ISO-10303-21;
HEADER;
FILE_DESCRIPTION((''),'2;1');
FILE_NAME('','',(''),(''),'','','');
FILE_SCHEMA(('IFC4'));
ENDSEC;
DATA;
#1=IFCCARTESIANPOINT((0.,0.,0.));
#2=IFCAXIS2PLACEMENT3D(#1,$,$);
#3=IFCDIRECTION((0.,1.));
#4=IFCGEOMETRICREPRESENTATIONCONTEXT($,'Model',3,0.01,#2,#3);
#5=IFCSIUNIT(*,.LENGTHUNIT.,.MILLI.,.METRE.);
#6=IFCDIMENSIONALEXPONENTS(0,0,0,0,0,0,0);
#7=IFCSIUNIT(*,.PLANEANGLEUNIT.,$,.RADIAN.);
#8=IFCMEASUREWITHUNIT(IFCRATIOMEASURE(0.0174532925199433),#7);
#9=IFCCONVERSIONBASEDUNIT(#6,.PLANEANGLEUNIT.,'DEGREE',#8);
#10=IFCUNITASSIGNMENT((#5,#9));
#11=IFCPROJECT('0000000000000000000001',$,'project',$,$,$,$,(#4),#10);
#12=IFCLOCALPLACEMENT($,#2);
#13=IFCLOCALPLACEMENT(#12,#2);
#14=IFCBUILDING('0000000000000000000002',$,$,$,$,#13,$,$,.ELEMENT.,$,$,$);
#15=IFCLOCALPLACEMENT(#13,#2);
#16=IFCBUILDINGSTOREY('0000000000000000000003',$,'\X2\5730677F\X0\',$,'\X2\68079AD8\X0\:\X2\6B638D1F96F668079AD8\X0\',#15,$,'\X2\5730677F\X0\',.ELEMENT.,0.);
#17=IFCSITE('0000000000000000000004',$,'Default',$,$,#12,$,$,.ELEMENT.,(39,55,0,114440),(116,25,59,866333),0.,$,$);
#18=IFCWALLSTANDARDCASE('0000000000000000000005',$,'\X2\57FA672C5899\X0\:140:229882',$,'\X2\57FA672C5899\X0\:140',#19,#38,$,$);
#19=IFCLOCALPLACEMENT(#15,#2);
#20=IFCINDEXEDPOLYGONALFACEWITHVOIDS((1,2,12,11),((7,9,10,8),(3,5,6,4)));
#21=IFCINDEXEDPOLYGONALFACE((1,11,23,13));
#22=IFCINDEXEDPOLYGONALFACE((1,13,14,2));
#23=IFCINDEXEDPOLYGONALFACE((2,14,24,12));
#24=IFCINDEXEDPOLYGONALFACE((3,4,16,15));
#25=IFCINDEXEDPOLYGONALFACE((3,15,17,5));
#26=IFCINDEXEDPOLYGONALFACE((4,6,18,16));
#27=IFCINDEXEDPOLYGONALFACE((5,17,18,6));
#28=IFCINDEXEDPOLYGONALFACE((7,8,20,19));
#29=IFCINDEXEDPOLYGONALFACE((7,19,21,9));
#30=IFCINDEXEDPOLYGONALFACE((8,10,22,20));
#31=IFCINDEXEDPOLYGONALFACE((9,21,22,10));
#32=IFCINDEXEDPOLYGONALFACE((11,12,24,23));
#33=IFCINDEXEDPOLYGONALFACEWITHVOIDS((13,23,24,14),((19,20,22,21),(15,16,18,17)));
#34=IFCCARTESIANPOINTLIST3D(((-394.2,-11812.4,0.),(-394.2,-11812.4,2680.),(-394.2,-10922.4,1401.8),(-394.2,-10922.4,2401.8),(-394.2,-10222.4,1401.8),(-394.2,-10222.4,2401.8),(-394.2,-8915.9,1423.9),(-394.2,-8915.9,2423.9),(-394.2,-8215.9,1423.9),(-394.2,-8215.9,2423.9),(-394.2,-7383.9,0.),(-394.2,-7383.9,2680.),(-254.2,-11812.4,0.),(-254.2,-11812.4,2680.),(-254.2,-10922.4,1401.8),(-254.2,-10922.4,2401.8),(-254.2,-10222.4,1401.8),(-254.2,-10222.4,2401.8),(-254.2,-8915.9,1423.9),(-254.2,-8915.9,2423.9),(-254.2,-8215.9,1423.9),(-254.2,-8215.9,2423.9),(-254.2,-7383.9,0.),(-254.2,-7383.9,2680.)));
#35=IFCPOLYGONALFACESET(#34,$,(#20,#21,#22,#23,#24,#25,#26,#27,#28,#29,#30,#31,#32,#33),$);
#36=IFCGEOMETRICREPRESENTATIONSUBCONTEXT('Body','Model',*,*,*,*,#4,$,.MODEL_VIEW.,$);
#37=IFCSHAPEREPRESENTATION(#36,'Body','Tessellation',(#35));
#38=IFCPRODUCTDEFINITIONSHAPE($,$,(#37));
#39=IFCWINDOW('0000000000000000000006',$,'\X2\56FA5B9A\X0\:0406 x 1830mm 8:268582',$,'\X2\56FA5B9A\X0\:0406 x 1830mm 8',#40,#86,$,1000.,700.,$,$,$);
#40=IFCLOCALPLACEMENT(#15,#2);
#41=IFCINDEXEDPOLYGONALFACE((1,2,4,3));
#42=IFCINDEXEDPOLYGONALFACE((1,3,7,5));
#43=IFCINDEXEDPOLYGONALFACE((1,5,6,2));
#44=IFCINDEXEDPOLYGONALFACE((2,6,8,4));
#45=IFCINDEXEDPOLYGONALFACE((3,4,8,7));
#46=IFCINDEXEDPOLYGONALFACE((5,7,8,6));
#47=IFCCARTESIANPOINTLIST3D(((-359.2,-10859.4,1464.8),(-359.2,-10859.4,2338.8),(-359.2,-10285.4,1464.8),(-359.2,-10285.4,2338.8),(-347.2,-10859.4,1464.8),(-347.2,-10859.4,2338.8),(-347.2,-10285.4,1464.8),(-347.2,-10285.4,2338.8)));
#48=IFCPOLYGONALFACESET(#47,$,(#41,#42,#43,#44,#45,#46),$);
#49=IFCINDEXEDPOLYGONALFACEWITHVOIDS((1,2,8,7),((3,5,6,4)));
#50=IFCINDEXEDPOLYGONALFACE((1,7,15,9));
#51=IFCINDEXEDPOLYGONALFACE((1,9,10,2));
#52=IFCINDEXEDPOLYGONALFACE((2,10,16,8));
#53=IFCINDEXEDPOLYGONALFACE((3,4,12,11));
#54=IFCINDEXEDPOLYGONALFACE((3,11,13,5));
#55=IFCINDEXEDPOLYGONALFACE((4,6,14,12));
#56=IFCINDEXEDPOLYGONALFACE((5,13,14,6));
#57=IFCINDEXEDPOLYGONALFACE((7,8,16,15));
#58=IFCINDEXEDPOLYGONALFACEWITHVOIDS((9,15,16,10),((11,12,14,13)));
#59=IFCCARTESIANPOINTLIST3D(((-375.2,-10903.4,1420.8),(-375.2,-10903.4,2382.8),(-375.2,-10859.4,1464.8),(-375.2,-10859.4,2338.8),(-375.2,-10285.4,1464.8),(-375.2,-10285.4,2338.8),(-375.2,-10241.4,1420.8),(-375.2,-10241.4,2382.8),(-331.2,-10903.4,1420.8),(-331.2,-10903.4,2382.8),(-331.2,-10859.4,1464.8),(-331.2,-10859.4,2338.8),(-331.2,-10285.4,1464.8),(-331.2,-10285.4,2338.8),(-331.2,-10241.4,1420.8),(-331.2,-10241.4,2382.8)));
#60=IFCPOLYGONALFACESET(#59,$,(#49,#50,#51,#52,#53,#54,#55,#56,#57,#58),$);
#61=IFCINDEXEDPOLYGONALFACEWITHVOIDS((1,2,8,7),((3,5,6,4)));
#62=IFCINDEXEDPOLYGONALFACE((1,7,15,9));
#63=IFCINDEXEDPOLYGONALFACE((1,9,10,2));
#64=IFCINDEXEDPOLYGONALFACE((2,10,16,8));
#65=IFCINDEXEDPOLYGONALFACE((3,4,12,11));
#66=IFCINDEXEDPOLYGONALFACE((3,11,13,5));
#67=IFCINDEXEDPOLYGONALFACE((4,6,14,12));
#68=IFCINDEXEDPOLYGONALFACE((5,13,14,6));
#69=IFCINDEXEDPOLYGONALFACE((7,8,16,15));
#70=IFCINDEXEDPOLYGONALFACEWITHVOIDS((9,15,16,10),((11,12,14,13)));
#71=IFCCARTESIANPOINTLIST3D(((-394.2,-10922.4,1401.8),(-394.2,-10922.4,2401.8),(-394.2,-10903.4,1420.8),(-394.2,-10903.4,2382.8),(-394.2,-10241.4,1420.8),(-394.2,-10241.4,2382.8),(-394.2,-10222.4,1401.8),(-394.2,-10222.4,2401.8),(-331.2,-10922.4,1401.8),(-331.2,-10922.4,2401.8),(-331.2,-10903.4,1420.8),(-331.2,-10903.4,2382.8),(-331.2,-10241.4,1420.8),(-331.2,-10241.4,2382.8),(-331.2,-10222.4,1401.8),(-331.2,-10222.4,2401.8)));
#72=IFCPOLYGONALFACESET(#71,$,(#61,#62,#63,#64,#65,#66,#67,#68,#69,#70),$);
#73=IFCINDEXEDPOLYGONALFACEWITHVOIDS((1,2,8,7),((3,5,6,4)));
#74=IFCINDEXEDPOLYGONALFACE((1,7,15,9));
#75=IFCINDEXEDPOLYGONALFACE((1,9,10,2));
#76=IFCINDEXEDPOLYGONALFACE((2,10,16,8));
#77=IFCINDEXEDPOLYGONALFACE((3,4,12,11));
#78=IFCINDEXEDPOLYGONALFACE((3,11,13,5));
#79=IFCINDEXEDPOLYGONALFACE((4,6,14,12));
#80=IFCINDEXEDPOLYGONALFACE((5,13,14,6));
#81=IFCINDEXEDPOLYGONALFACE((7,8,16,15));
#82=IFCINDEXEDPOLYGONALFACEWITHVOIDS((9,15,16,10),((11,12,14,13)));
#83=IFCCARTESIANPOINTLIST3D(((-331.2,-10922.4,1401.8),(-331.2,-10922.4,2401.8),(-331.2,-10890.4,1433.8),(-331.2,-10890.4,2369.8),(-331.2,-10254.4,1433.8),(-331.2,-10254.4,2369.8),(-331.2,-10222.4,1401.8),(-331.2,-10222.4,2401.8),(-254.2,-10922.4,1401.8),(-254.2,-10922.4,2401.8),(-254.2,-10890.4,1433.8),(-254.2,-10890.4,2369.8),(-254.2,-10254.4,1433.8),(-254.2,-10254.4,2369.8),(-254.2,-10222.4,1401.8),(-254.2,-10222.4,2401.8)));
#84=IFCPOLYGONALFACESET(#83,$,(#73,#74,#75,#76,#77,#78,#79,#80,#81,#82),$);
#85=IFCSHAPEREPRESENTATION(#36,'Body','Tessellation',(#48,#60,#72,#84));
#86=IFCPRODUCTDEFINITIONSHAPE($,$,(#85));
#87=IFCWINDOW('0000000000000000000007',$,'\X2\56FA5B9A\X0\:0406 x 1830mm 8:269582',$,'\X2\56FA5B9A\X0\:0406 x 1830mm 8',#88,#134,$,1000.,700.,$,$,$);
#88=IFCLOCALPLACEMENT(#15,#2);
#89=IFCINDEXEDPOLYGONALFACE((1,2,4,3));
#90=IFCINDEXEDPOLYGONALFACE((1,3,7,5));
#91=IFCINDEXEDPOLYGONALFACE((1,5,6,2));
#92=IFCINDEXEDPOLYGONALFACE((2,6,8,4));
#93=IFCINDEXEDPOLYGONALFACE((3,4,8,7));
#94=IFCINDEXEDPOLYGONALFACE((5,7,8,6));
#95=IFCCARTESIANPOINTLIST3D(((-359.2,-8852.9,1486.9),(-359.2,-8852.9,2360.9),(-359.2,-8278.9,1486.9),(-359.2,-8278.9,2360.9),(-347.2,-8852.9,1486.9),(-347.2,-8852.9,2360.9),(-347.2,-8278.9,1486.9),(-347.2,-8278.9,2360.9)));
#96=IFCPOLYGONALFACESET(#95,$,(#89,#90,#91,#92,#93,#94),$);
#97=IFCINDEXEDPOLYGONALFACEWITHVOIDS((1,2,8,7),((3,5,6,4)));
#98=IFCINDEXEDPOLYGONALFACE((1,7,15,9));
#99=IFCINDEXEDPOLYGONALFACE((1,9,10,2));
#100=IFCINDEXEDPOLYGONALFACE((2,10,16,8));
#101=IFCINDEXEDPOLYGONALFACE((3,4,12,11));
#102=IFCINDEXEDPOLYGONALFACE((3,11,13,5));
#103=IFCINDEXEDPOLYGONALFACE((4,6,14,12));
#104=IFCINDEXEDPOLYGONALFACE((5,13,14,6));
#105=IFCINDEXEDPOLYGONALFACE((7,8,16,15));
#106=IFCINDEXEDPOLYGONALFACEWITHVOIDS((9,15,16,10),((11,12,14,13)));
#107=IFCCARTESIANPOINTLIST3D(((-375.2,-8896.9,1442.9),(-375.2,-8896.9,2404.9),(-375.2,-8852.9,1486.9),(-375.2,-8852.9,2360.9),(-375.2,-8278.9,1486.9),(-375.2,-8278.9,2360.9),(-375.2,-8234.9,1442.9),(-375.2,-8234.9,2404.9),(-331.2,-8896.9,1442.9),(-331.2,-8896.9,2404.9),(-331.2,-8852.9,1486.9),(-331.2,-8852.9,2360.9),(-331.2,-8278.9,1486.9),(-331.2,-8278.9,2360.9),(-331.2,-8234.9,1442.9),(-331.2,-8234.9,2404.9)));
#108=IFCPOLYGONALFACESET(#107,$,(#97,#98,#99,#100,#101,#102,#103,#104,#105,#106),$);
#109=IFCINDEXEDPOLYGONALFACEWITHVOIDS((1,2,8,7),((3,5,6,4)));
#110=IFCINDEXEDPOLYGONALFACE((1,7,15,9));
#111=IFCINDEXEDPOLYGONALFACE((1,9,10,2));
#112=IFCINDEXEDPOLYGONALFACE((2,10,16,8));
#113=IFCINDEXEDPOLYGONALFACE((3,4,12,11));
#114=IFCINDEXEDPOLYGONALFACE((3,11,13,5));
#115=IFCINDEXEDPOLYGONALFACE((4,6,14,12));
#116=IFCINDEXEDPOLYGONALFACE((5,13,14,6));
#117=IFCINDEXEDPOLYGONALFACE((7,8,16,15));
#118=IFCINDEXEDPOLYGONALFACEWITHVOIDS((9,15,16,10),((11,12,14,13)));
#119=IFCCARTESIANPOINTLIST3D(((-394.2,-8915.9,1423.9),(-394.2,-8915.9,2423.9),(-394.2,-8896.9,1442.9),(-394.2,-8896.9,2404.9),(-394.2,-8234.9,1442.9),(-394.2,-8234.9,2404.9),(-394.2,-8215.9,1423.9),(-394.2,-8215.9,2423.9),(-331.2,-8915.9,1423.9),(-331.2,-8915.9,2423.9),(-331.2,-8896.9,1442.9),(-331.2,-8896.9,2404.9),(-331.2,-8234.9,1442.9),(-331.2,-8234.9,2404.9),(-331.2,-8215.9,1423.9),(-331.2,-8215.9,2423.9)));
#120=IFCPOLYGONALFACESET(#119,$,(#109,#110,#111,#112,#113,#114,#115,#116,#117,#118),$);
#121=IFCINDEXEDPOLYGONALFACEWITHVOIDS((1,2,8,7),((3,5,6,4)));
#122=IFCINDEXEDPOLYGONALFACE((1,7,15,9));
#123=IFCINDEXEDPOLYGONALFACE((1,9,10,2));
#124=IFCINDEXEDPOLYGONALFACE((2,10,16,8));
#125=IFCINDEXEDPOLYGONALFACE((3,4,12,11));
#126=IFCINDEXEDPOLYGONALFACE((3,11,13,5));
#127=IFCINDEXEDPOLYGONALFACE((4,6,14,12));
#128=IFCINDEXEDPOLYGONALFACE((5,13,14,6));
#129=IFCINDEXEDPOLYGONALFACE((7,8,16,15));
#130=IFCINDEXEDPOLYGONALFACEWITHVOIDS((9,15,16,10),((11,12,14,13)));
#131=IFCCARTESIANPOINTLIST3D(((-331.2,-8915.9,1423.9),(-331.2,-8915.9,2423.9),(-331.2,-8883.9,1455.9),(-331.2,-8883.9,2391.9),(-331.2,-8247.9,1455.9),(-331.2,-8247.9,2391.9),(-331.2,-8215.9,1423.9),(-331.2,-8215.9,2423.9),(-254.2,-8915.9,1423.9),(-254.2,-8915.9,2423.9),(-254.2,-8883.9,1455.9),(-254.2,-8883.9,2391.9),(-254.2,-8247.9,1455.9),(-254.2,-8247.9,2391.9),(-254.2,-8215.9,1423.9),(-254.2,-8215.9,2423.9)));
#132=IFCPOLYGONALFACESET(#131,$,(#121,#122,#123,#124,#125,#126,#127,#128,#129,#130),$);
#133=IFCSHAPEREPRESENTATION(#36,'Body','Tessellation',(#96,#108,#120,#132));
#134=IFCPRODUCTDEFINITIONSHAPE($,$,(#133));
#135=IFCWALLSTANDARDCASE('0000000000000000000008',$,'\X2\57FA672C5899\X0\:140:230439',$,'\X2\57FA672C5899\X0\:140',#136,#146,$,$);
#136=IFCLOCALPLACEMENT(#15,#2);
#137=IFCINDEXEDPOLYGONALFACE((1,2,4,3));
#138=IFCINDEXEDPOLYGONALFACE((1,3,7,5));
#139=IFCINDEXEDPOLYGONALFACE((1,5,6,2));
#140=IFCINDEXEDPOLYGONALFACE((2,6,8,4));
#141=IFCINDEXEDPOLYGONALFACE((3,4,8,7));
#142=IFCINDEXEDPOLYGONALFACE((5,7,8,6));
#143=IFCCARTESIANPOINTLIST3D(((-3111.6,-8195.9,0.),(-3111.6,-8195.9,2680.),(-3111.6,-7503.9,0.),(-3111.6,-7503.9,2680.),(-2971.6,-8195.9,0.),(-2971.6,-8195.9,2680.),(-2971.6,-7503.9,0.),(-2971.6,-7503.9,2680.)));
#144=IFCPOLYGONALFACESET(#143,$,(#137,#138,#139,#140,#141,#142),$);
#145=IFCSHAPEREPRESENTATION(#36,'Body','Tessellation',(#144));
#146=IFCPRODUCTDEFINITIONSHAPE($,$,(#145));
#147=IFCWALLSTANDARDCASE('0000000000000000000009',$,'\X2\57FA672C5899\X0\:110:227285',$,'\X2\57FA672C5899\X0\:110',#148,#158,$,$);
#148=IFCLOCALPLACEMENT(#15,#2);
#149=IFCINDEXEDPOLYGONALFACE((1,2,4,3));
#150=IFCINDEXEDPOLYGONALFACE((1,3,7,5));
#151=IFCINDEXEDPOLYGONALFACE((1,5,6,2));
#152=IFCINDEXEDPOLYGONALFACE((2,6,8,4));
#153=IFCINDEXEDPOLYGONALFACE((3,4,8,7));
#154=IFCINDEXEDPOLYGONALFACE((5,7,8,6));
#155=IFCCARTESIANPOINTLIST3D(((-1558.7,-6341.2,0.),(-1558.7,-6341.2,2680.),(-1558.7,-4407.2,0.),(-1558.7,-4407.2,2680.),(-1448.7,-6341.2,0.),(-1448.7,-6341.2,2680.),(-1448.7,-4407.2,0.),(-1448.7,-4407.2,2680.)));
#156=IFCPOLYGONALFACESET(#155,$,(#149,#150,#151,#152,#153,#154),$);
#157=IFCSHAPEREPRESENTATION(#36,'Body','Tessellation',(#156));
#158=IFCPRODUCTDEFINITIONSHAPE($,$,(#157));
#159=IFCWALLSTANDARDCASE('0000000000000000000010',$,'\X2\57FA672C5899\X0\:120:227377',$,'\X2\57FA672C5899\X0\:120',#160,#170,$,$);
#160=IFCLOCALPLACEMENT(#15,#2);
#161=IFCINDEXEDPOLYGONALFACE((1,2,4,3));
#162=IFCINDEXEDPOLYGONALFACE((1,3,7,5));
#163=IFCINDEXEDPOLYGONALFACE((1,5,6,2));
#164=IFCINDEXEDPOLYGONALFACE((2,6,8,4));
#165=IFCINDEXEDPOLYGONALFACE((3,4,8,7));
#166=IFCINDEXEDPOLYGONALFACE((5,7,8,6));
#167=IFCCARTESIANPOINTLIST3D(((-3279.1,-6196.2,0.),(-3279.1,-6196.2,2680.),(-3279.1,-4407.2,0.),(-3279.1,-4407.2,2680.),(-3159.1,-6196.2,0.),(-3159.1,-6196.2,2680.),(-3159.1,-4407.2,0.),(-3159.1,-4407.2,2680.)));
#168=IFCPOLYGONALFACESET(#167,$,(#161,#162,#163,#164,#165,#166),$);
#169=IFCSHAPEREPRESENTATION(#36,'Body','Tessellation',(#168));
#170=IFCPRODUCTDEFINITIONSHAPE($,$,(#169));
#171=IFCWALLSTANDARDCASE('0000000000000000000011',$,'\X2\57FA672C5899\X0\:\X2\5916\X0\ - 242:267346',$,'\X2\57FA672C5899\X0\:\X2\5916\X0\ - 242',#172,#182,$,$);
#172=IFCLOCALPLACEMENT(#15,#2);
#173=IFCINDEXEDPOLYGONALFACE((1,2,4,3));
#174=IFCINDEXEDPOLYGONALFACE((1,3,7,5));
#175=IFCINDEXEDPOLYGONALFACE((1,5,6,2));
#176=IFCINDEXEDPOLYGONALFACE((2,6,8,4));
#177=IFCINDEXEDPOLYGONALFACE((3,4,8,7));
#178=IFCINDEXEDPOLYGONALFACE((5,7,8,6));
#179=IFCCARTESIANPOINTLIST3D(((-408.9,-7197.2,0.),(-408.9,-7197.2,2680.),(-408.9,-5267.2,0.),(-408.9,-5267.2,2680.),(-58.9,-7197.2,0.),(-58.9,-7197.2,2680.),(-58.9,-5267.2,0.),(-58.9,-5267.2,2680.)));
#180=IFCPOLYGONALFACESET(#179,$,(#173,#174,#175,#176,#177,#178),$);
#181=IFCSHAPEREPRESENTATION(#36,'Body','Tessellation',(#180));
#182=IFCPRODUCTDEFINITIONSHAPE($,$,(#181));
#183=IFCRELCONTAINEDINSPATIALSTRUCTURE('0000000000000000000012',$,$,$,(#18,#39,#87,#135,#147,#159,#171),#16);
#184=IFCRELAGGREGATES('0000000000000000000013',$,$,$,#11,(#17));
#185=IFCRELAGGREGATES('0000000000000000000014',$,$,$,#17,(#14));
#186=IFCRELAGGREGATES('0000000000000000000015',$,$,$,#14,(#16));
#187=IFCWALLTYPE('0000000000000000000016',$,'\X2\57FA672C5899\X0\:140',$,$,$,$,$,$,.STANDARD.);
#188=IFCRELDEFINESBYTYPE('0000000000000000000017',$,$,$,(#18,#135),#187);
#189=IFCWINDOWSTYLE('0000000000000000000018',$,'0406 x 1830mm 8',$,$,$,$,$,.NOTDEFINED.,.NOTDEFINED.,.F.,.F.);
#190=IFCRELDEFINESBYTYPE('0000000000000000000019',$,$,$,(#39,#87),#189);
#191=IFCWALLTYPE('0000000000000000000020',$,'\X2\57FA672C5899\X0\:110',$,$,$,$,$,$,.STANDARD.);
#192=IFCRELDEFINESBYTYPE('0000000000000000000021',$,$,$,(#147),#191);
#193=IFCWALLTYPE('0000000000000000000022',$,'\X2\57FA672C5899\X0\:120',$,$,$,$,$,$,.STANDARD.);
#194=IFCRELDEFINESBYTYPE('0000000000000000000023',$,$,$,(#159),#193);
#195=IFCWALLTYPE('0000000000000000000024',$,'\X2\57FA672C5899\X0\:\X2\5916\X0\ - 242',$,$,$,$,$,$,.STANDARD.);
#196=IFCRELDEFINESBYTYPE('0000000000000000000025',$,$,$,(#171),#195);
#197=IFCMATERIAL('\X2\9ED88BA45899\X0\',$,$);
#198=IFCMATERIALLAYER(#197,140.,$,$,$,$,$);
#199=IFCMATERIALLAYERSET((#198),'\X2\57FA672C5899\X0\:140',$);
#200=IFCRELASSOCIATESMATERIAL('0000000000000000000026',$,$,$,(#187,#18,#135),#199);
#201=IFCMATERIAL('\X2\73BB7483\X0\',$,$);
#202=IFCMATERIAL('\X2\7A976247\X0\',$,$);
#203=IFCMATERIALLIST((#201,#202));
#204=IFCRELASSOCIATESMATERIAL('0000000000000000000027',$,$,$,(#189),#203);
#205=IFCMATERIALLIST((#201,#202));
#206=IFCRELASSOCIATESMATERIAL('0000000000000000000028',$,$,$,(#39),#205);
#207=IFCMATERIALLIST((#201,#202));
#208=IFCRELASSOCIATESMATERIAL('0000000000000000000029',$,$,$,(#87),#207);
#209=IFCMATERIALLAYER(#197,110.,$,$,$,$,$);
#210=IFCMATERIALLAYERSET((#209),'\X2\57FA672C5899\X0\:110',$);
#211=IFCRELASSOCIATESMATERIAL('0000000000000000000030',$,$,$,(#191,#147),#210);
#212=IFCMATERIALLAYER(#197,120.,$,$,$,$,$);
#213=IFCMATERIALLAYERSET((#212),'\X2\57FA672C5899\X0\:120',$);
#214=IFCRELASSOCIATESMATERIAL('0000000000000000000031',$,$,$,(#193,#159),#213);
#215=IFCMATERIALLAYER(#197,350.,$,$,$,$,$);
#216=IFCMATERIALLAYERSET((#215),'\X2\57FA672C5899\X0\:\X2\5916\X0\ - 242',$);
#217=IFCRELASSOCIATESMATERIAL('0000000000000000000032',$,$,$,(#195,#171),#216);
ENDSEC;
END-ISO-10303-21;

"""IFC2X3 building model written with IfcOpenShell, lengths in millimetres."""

from ifc_helpers import new_model, entity, si_unit, converted_unit, direction, frame, frame_2d, origin, origin_2d_with_axis, place, context, subcontext, project, spatial, polyline, rectangle, outline, extrude, source, transform, mapped, material, material_list, layer, layer_set, layer_usage, type_object, type_shapes, element, fill, save


model = new_model("IFC2X3")

# Units and contexts
model_context = context("Model", 3, precision=0.01, world=origin(), true_north=direction((0.0, 1.0)))
body_context = subcontext(model_context, "Body", "Model", "MODEL_VIEW")
ifc_project = project(units=[si_unit("LENGTHUNIT", "METRE", prefix="MILLI"), converted_unit("PLANEANGLEUNIT", "DEGREE", entity("IfcRatioMeasure", 0.0174532925199433), si_unit("PLANEANGLEUNIT", "RADIAN"), dimensions=[0, 0, 0, 0, 0, 0, 0])], contexts=[model_context])

# Site, building, storey
site_placement = place(None, origin())
site = spatial("IfcSite", under=ifc_project, at=site_placement, Name="Default", CompositionType="ELEMENT", RefLatitude=(39, 55, 0, 114440), RefLongitude=(116, 25, 59, 866333), RefElevation=0.0)
building_placement = place(site_placement, origin())
building = spatial("IfcBuilding", under=site, at=building_placement, CompositionType="ELEMENT")
storey_placement = place(building_placement, origin())
storey = spatial("IfcBuildingStorey", under=building, at=storey_placement, Name="地板", ObjectType="标高:正负零标高", LongName="地板", CompositionType="ELEMENT", Elevation=0.0)

# Shared definitions
ifc_material_1 = material(Name="默认墙")

# Shared definitions
ifc_material_2 = material(Name="玻璃")
ifc_material_3 = material(Name="窗扇")

# Shared definitions
ifc_layer_1 = layer(ifc_material_1, 140.0)
ifc_layer_set_1 = layer_set([ifc_layer_1], Name="基本墙:140")
wall_type_1 = type_object("IfcWallType", Name="基本墙:140", PredefinedType="STANDARD", material=ifc_layer_set_1)

# Wall, openings, windows
ifc_layer_usage_1 = layer_usage(ifc_layer_set_1, "AXIS2", "NEGATIVE", 70.0)
wall_1_placement = place(storey_placement, frame((-324.2, -11812.4, 0.0), z_axis=(0.0, 0.0, 1.0), x_axis=(0.0, 1.0, 0.0)))
wall_1 = element("IfcWallStandardCase", 1, at=wall_1_placement, inside=storey, type_object=wall_type_1, material=ifc_layer_usage_1, Name="基本墙:140:229882", ObjectType="基本墙:140", context=body_context, shape_type="SweptSolid", body=[
    extrude(rectangle(XDim=4428.5, YDim=140.0, at=frame_2d((2214.3, 0.0), x_axis=(-1.0, 0.0))), origin(), (0.0, 0.0, 1.0), 2680.0),
])
opening_1_placement = place(wall_1_placement, frame((890.0, -70.0, 1401.8)))
opening_1 = element("IfcOpeningElement", 2, at=opening_1_placement, cuts=wall_1, ObjectType="Opening", context=body_context, shape_type="SweptSolid", body=[
    extrude(rectangle(XDim=1000.0, YDim=700.0, at=frame_2d((500.0, 350.0), x_axis=(1.0, 0.0))), frame((0.0, 0.0, 0.0), z_axis=(0.0, 1.0, 0.0), x_axis=(0.0, 0.0, 1.0)), (0.0, 0.0, 1.0), 140.0),
])
opening_2_placement = place(wall_1_placement, frame((2896.5, -70.0, 1423.9)))
opening_2 = element("IfcOpeningElement", 3, at=opening_2_placement, cuts=wall_1, ObjectType="Opening", context=body_context, shape_type="SweptSolid", body=[
    extrude(rectangle(XDim=1000.0, YDim=700.0, at=frame_2d((500.0, 350.0), x_axis=(1.0, 0.0))), frame((0.0, 0.0, 0.0), z_axis=(0.0, 1.0, 0.0), x_axis=(0.0, 0.0, 1.0)), (0.0, 0.0, 1.0), 140.0),
])
ifc_material_list_1 = material_list([ifc_material_2, ifc_material_3])
ifc_material_list_2 = material_list([ifc_material_2, ifc_material_3])
window_style_1 = type_object("IfcWindowStyle", Name="0406 x 1830mm 8", ConstructionType="NOTDEFINED", OperationType="NOTDEFINED", ParameterTakesPrecedence=False, Sizeable=False, material=ifc_material_list_2)
shared_shape_1 = source(origin(), body_context, "Body", "SweptSolid", [
    extrude(rectangle(XDim=12.0, YDim=574.0, at=origin_2d_with_axis()), frame((350.0, 99.0, 63.0), z_axis=(0.0, 0.0, 1.0), x_axis=(0.0, -1.0, 0.0)), (0.0, 0.0, 1.0), 874.0),
    extrude(outline(polyline([(-331.0, -481.0), (331.0, -481.0), (331.0, 481.0), (-331.0, 481.0), (-331.0, -481.0)]), holes=[polyline([(-287.0, -437.0), (-287.0, 437.0), (287.0, 437.0), (287.0, -437.0), (-287.0, -437.0)])]), frame((350.0, 77.0, 500.0), z_axis=(0.0, 1.0, 0.0), x_axis=(1.0, 0.0, 0.0)), (0.0, 0.0, 1.0), 44.0),
    extrude(outline(polyline([(-350.0, -500.0), (350.0, -500.0), (350.0, 500.0), (-350.0, 500.0), (-350.0, -500.0)]), holes=[polyline([(-331.0, -481.0), (-331.0, 481.0), (331.0, 481.0), (331.0, -481.0), (-331.0, -481.0)])]), frame((350.0, 77.0, 500.0), z_axis=(0.0, 1.0, 0.0), x_axis=(1.0, 0.0, 0.0)), (0.0, 0.0, 1.0), 63.0),
    extrude(outline(polyline([(-350.0, -500.0), (350.0, -500.0), (350.0, 500.0), (-350.0, 500.0), (-350.0, -500.0)]), holes=[polyline([(-318.0, -468.0), (-318.0, 468.0), (318.0, 468.0), (318.0, -468.0), (-318.0, -468.0)])]), frame((350.0, 0.0, 500.0), z_axis=(0.0, 1.0, 0.0), x_axis=(1.0, 0.0, 0.0)), (0.0, 0.0, 1.0), 77.0),
])
type_shapes(window_style_1, [shared_shape_1])
window_1_placement = place(opening_1_placement, origin())
window_1 = element("IfcWindow", 4, at=window_1_placement, inside=storey, type_object=window_style_1, material=ifc_material_list_1, Name="固定:0406 x 1830mm 8:268582", ObjectType="固定:0406 x 1830mm 8", OverallHeight=1000.0, OverallWidth=700.0, context=body_context, shape_type="MappedRepresentation", body=[
    mapped(shared_shape_1, transform((0.0, 0.0, 0.0), scale=1.0)),
])
fill(opening_1, window_1)
ifc_material_list_3 = material_list([ifc_material_2, ifc_material_3])
window_2_placement = place(opening_2_placement, origin())
window_2 = element("IfcWindow", 5, at=window_2_placement, inside=storey, type_object=window_style_1, material=ifc_material_list_3, Name="固定:0406 x 1830mm 8:269582", ObjectType="固定:0406 x 1830mm 8", OverallHeight=1000.0, OverallWidth=700.0, context=body_context, shape_type="MappedRepresentation", body=[
    mapped(shared_shape_1, transform((0.0, 0.0, 0.0), scale=1.0)),
])
fill(opening_2, window_2)

# Walls
ifc_layer_usage_2 = layer_usage(ifc_layer_set_1, "AXIS2", "NEGATIVE", 70.0)
wall_2_placement = place(storey_placement, frame((-3041.6, -7503.9, 0.0), z_axis=(0.0, 0.0, 1.0), x_axis=(0.0, -1.0, 0.0)))
element("IfcWallStandardCase", 6, at=wall_2_placement, inside=storey, type_object=wall_type_1, material=ifc_layer_usage_2, Name="基本墙:140:230439", ObjectType="基本墙:140", context=body_context, shape_type="SweptSolid", body=[
    extrude(rectangle(XDim=692.0, YDim=140.0, at=frame_2d((346.0, 0.0), x_axis=(-1.0, 0.0))), origin(), (0.0, 0.0, 1.0), 2680.0),
])
ifc_layer_2 = layer(ifc_material_1, 110.0)
ifc_layer_set_2 = layer_set([ifc_layer_2], Name="基本墙:110")
ifc_layer_usage_3 = layer_usage(ifc_layer_set_2, "AXIS2", "NEGATIVE", 55.0)
wall_type_2 = type_object("IfcWallType", Name="基本墙:110", PredefinedType="STANDARD", material=ifc_layer_set_2)
wall_3_placement = place(storey_placement, frame((-1503.7, -4407.2, 0.0), z_axis=(0.0, 0.0, 1.0), x_axis=(0.0, -1.0, 0.0)))
element("IfcWallStandardCase", 7, at=wall_3_placement, inside=storey, type_object=wall_type_2, material=ifc_layer_usage_3, Name="基本墙:110:227285", ObjectType="基本墙:110", context=body_context, shape_type="SweptSolid", body=[
    extrude(rectangle(XDim=1934.0, YDim=110.0, at=frame_2d((967.0, 0.0), x_axis=(-1.0, 0.0))), origin(), (0.0, 0.0, 1.0), 2680.0),
])
ifc_layer_3 = layer(ifc_material_1, 120.0)
ifc_layer_set_3 = layer_set([ifc_layer_3], Name="基本墙:120")
ifc_layer_usage_4 = layer_usage(ifc_layer_set_3, "AXIS2", "NEGATIVE", 60.0)
wall_type_3 = type_object("IfcWallType", Name="基本墙:120", PredefinedType="STANDARD", material=ifc_layer_set_3)
wall_4_placement = place(storey_placement, frame((-3219.1, -4407.2, 0.0), z_axis=(0.0, 0.0, 1.0), x_axis=(0.0, -1.0, 0.0)))
element("IfcWallStandardCase", 8, at=wall_4_placement, inside=storey, type_object=wall_type_3, material=ifc_layer_usage_4, Name="基本墙:120:227377", ObjectType="基本墙:120", context=body_context, shape_type="SweptSolid", body=[
    extrude(rectangle(XDim=1789.0, YDim=120.0, at=frame_2d((894.5, 0.0), x_axis=(-1.0, 0.0))), origin(), (0.0, 0.0, 1.0), 2680.0),
])
ifc_layer_4 = layer(ifc_material_1, 350.0)
ifc_layer_set_4 = layer_set([ifc_layer_4], Name="基本墙:外 - 242")
ifc_layer_usage_5 = layer_usage(ifc_layer_set_4, "AXIS2", "NEGATIVE", 175.0)
wall_type_4 = type_object("IfcWallType", Name="基本墙:外 - 242", PredefinedType="STANDARD", material=ifc_layer_set_4)
wall_5_placement = place(storey_placement, frame((-233.9, -5267.2, 0.0), z_axis=(0.0, 0.0, 1.0), x_axis=(0.0, -1.0, 0.0)))
element("IfcWallStandardCase", 9, at=wall_5_placement, inside=storey, type_object=wall_type_4, material=ifc_layer_usage_5, Name="基本墙:外 - 242:267346", ObjectType="基本墙:外 - 242", context=body_context, shape_type="SweptSolid", body=[
    extrude(rectangle(XDim=1930.0, YDim=350.0, at=frame_2d((965.0, 0.0), x_axis=(-1.0, 0.0))), origin(), (0.0, 0.0, 1.0), 2680.0),
])

save(model, "model.ifc")
